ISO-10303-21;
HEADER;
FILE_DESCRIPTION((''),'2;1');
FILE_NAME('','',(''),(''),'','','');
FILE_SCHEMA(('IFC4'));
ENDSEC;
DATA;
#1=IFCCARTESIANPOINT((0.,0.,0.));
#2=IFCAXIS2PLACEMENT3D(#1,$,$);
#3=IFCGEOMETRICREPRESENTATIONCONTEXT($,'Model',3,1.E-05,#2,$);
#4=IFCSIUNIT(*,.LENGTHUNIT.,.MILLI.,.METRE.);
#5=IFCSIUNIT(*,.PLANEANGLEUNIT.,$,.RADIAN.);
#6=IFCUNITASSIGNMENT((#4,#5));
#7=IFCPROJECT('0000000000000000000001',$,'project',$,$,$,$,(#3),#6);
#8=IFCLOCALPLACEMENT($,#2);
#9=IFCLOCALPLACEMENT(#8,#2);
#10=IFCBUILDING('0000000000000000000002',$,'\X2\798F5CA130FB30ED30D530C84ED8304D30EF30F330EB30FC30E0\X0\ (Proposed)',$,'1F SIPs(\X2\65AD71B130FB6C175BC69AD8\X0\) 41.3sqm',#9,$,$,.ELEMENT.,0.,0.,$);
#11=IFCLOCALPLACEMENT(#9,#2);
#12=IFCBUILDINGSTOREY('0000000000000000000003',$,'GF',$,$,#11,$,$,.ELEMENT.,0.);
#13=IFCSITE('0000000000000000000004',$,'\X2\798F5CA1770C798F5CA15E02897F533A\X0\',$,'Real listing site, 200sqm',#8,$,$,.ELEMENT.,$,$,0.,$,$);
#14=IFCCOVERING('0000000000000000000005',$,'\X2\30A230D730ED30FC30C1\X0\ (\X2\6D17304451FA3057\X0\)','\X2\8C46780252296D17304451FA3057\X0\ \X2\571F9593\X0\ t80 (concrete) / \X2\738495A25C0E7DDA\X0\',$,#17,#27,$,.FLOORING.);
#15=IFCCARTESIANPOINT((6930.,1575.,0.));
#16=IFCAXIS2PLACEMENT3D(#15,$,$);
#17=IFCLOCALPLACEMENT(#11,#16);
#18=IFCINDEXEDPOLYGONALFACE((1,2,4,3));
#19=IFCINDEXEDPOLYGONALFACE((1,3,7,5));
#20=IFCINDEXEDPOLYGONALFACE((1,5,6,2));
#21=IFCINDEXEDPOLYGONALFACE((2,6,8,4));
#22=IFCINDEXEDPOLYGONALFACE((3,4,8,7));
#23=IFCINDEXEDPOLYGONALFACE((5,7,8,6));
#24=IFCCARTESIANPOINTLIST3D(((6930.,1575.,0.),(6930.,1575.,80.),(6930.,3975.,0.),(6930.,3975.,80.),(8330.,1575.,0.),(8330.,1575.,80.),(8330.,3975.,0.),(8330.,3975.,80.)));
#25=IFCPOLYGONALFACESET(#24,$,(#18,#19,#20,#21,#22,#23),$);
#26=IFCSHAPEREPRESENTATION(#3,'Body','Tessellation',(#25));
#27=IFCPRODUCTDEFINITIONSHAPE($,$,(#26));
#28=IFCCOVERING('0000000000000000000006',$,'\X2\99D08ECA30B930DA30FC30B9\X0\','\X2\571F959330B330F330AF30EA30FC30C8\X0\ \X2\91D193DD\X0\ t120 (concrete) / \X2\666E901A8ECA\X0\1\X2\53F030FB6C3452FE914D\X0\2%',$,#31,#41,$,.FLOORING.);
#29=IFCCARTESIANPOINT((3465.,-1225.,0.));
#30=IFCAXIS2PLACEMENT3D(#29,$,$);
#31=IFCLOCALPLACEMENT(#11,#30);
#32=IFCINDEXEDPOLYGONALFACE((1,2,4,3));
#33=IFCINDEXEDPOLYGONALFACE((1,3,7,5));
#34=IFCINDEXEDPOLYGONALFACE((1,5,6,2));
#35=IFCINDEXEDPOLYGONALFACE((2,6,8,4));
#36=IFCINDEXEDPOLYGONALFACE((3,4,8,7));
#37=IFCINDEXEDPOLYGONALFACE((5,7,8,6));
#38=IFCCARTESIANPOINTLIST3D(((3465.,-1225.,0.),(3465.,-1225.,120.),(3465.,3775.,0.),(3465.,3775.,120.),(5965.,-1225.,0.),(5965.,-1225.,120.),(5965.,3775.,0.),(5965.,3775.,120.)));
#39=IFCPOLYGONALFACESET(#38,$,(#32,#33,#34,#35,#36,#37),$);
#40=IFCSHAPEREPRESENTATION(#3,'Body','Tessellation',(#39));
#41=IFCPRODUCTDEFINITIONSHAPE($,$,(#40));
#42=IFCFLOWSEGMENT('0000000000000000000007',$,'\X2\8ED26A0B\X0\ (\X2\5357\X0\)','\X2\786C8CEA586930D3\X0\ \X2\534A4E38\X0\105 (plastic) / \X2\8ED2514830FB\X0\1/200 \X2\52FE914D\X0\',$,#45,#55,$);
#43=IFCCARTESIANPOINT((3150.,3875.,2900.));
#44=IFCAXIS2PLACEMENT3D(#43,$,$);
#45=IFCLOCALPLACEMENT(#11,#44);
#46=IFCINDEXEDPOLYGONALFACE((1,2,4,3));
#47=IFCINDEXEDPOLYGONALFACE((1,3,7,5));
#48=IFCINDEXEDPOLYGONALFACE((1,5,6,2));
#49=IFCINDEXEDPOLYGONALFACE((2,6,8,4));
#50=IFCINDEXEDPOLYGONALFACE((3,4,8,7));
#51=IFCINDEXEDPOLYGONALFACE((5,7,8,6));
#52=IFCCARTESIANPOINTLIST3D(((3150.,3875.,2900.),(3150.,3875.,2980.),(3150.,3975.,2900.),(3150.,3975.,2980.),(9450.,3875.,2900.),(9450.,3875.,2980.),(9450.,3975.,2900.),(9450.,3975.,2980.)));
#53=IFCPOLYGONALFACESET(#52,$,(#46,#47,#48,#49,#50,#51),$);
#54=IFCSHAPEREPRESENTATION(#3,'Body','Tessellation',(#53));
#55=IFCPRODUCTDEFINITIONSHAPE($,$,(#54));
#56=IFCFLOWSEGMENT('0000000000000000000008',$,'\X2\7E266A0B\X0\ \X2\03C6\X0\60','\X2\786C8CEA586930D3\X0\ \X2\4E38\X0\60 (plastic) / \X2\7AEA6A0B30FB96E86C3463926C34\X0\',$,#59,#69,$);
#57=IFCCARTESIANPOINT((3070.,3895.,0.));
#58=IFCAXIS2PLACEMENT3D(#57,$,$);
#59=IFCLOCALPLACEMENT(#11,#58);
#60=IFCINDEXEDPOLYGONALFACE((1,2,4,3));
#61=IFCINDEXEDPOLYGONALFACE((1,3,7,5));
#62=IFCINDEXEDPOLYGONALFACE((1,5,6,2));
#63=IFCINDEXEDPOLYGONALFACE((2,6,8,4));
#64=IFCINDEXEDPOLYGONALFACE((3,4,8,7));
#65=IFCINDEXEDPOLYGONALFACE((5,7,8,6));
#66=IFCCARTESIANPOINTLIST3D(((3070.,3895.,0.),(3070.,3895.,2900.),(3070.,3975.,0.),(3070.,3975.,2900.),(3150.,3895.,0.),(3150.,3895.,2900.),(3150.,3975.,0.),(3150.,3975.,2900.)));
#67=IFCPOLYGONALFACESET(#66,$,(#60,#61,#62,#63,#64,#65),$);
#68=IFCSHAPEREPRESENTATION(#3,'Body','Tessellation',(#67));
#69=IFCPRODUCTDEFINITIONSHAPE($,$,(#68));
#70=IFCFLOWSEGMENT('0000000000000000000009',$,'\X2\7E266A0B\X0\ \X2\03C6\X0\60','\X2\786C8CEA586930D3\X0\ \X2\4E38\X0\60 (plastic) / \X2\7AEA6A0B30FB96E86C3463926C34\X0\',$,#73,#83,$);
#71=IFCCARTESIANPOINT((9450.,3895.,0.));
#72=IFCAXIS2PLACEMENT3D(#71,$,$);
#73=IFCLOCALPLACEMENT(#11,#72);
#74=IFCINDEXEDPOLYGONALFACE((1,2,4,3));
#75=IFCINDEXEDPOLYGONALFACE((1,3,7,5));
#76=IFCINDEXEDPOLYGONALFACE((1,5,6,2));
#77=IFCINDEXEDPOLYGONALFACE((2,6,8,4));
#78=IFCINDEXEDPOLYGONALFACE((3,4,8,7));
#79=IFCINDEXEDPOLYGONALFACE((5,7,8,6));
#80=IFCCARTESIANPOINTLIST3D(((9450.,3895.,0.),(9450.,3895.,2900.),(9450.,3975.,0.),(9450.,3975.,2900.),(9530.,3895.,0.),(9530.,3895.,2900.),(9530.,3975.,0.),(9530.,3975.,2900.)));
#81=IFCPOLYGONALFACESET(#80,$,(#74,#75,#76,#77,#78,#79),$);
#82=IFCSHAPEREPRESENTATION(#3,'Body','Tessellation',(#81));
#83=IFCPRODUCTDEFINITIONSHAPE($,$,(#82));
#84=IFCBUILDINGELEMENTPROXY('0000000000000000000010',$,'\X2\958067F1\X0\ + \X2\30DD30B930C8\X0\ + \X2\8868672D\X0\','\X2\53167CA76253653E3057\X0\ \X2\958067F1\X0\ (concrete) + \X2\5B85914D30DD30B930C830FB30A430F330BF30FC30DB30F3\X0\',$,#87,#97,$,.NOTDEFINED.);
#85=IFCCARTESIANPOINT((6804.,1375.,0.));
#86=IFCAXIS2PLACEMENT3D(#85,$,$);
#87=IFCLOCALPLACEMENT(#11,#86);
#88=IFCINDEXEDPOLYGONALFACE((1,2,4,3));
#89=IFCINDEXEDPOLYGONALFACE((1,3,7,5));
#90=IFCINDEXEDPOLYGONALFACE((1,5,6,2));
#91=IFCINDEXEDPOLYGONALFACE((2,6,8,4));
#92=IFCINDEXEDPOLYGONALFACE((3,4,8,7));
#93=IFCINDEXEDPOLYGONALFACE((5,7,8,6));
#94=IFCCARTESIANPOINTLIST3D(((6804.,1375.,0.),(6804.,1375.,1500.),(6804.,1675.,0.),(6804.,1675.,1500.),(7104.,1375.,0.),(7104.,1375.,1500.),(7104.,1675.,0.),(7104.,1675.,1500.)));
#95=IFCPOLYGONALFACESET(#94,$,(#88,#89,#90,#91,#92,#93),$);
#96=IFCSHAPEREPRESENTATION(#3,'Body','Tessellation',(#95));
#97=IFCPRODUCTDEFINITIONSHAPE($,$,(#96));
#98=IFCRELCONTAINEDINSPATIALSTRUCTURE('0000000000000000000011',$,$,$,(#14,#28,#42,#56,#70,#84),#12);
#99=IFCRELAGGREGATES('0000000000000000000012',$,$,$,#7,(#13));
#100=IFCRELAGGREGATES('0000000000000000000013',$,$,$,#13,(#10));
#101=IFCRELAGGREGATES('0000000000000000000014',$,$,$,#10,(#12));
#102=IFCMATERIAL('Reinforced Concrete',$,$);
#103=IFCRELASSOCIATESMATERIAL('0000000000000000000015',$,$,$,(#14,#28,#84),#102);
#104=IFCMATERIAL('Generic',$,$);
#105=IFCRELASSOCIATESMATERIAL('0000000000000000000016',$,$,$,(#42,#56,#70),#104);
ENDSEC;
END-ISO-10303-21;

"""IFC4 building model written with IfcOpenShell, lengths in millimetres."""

from ifc_helpers import new_model, si_unit, frame, frame_2d, origin, place, context, project, spatial, rectangle, extrude, material, element, save


model = new_model("IFC4")

# Units and contexts
model_context = context("Model", 3, precision=1e-05, world=origin())
ifc_project = project(units=[si_unit("LENGTHUNIT", "METRE", prefix="MILLI"), si_unit("PLANEANGLEUNIT", "RADIAN")], contexts=[model_context])

# Site, building, storey
site_placement = place(None, origin())
site = spatial("IfcSite", under=ifc_project, at=site_placement, Name="福岡県福岡市西区", ObjectType="Real listing site, 200sqm", CompositionType="ELEMENT", RefElevation=0.0)
building_placement = place(site_placement, origin())
building = spatial("IfcBuilding", under=site, at=building_placement, Name="福岡・ロフト付きワンルーム (Proposed)", ObjectType="1F SIPs(断熱・気密高) 41.3sqm", CompositionType="ELEMENT", ElevationOfRefHeight=0.0, ElevationOfTerrain=0.0)
storey_placement = place(building_placement, origin())
storey = spatial("IfcBuildingStorey", under=building, at=storey_placement, Name="GF", CompositionType="ELEMENT", Elevation=0.0)

# Shared definitions
ifc_material_1 = material(Name="Reinforced Concrete")

# Coverings
ifc_material_2 = material(Name="Generic")
covering_1_placement = place(storey_placement, frame((6930.0, 1575.0, 0.0)))
element("IfcCovering", 1, at=covering_1_placement, inside=storey, material=ifc_material_1, Name="アプローチ (洗い出し)", Description="豆砂利洗い出し 土間 t80 (concrete) / 玄関導線", PredefinedType="FLOORING", context=model_context, shape_type="SweptSolid", body=[
    extrude(rectangle(XDim=1400.0, YDim=2400.0, at=frame_2d((700.0, 1200.0))), frame((6930.0, 1575.0, 0.0)), (0.0, 0.0, 1.0), 80.0),
])
covering_2_placement = place(storey_placement, frame((3465.0, -1225.0, 0.0)))
element("IfcCovering", 2, at=covering_2_placement, inside=storey, material=ifc_material_1, Name="駐車スペース", Description="土間コンクリート 金鏝 t120 (concrete) / 普通車1台・水勾配2%", PredefinedType="FLOORING", context=model_context, shape_type="SweptSolid", body=[
    extrude(rectangle(XDim=2500.0, YDim=5000.0, at=frame_2d((1250.0, 2500.0))), frame((3465.0, -1225.0, 0.0)), (0.0, 0.0, 1.0), 120.0),
])

# Flow segments
flow_segment_1_placement = place(storey_placement, frame((3150.0, 3875.0, 2900.0)))
element("IfcFlowSegment", 3, at=flow_segment_1_placement, inside=storey, material=ifc_material_2, Name="軒樋 (南)", Description="硬質塩ビ 半丸105 (plastic) / 軒先・1/200 勾配", context=model_context, shape_type="SweptSolid", body=[
    extrude(rectangle(XDim=6300.0, YDim=100.0, at=frame_2d((3150.0, 50.0))), frame((3150.0, 3875.0, 2900.0)), (0.0, 0.0, 1.0), 80.0),
])
flow_segment_2_placement = place(storey_placement, frame((3070.0, 3895.0, 0.0)))
element("IfcFlowSegment", 4, at=flow_segment_2_placement, inside=storey, material=ifc_material_2, Name="縦樋 φ60", Description="硬質塩ビ 丸60 (plastic) / 竪樋・雨水排水", context=model_context, shape_type="SweptSolid", body=[
    extrude(rectangle(XDim=80.0, YDim=80.0, at=frame_2d((40.0, 40.0))), frame((3070.0, 3895.0, 0.0)), (0.0, 0.0, 1.0), 2900.0),
])
flow_segment_3_placement = place(storey_placement, frame((9450.0, 3895.0, 0.0)))
element("IfcFlowSegment", 5, at=flow_segment_3_placement, inside=storey, material=ifc_material_2, Name="縦樋 φ60", Description="硬質塩ビ 丸60 (plastic) / 竪樋・雨水排水", context=model_context, shape_type="SweptSolid", body=[
    extrude(rectangle(XDim=80.0, YDim=80.0, at=frame_2d((40.0, 40.0))), frame((9450.0, 3895.0, 0.0)), (0.0, 0.0, 1.0), 2900.0),
])

# Building element proxy
proxy_placement = place(storey_placement, frame((6804.0, 1375.0, 0.0)))
element("IfcBuildingElementProxy", 6, at=proxy_placement, inside=storey, material=ifc_material_1, Name="門柱 + ポスト + 表札", Description="化粧打放し 門柱 (concrete) + 宅配ポスト・インターホン", PredefinedType="NOTDEFINED", context=model_context, shape_type="SweptSolid", body=[
    extrude(rectangle(XDim=300.0, YDim=300.0, at=frame_2d((150.0, 150.0))), frame((6804.0, 1375.0, 0.0)), (0.0, 0.0, 1.0), 1500.0),
])

save(model, "model.ifc")
